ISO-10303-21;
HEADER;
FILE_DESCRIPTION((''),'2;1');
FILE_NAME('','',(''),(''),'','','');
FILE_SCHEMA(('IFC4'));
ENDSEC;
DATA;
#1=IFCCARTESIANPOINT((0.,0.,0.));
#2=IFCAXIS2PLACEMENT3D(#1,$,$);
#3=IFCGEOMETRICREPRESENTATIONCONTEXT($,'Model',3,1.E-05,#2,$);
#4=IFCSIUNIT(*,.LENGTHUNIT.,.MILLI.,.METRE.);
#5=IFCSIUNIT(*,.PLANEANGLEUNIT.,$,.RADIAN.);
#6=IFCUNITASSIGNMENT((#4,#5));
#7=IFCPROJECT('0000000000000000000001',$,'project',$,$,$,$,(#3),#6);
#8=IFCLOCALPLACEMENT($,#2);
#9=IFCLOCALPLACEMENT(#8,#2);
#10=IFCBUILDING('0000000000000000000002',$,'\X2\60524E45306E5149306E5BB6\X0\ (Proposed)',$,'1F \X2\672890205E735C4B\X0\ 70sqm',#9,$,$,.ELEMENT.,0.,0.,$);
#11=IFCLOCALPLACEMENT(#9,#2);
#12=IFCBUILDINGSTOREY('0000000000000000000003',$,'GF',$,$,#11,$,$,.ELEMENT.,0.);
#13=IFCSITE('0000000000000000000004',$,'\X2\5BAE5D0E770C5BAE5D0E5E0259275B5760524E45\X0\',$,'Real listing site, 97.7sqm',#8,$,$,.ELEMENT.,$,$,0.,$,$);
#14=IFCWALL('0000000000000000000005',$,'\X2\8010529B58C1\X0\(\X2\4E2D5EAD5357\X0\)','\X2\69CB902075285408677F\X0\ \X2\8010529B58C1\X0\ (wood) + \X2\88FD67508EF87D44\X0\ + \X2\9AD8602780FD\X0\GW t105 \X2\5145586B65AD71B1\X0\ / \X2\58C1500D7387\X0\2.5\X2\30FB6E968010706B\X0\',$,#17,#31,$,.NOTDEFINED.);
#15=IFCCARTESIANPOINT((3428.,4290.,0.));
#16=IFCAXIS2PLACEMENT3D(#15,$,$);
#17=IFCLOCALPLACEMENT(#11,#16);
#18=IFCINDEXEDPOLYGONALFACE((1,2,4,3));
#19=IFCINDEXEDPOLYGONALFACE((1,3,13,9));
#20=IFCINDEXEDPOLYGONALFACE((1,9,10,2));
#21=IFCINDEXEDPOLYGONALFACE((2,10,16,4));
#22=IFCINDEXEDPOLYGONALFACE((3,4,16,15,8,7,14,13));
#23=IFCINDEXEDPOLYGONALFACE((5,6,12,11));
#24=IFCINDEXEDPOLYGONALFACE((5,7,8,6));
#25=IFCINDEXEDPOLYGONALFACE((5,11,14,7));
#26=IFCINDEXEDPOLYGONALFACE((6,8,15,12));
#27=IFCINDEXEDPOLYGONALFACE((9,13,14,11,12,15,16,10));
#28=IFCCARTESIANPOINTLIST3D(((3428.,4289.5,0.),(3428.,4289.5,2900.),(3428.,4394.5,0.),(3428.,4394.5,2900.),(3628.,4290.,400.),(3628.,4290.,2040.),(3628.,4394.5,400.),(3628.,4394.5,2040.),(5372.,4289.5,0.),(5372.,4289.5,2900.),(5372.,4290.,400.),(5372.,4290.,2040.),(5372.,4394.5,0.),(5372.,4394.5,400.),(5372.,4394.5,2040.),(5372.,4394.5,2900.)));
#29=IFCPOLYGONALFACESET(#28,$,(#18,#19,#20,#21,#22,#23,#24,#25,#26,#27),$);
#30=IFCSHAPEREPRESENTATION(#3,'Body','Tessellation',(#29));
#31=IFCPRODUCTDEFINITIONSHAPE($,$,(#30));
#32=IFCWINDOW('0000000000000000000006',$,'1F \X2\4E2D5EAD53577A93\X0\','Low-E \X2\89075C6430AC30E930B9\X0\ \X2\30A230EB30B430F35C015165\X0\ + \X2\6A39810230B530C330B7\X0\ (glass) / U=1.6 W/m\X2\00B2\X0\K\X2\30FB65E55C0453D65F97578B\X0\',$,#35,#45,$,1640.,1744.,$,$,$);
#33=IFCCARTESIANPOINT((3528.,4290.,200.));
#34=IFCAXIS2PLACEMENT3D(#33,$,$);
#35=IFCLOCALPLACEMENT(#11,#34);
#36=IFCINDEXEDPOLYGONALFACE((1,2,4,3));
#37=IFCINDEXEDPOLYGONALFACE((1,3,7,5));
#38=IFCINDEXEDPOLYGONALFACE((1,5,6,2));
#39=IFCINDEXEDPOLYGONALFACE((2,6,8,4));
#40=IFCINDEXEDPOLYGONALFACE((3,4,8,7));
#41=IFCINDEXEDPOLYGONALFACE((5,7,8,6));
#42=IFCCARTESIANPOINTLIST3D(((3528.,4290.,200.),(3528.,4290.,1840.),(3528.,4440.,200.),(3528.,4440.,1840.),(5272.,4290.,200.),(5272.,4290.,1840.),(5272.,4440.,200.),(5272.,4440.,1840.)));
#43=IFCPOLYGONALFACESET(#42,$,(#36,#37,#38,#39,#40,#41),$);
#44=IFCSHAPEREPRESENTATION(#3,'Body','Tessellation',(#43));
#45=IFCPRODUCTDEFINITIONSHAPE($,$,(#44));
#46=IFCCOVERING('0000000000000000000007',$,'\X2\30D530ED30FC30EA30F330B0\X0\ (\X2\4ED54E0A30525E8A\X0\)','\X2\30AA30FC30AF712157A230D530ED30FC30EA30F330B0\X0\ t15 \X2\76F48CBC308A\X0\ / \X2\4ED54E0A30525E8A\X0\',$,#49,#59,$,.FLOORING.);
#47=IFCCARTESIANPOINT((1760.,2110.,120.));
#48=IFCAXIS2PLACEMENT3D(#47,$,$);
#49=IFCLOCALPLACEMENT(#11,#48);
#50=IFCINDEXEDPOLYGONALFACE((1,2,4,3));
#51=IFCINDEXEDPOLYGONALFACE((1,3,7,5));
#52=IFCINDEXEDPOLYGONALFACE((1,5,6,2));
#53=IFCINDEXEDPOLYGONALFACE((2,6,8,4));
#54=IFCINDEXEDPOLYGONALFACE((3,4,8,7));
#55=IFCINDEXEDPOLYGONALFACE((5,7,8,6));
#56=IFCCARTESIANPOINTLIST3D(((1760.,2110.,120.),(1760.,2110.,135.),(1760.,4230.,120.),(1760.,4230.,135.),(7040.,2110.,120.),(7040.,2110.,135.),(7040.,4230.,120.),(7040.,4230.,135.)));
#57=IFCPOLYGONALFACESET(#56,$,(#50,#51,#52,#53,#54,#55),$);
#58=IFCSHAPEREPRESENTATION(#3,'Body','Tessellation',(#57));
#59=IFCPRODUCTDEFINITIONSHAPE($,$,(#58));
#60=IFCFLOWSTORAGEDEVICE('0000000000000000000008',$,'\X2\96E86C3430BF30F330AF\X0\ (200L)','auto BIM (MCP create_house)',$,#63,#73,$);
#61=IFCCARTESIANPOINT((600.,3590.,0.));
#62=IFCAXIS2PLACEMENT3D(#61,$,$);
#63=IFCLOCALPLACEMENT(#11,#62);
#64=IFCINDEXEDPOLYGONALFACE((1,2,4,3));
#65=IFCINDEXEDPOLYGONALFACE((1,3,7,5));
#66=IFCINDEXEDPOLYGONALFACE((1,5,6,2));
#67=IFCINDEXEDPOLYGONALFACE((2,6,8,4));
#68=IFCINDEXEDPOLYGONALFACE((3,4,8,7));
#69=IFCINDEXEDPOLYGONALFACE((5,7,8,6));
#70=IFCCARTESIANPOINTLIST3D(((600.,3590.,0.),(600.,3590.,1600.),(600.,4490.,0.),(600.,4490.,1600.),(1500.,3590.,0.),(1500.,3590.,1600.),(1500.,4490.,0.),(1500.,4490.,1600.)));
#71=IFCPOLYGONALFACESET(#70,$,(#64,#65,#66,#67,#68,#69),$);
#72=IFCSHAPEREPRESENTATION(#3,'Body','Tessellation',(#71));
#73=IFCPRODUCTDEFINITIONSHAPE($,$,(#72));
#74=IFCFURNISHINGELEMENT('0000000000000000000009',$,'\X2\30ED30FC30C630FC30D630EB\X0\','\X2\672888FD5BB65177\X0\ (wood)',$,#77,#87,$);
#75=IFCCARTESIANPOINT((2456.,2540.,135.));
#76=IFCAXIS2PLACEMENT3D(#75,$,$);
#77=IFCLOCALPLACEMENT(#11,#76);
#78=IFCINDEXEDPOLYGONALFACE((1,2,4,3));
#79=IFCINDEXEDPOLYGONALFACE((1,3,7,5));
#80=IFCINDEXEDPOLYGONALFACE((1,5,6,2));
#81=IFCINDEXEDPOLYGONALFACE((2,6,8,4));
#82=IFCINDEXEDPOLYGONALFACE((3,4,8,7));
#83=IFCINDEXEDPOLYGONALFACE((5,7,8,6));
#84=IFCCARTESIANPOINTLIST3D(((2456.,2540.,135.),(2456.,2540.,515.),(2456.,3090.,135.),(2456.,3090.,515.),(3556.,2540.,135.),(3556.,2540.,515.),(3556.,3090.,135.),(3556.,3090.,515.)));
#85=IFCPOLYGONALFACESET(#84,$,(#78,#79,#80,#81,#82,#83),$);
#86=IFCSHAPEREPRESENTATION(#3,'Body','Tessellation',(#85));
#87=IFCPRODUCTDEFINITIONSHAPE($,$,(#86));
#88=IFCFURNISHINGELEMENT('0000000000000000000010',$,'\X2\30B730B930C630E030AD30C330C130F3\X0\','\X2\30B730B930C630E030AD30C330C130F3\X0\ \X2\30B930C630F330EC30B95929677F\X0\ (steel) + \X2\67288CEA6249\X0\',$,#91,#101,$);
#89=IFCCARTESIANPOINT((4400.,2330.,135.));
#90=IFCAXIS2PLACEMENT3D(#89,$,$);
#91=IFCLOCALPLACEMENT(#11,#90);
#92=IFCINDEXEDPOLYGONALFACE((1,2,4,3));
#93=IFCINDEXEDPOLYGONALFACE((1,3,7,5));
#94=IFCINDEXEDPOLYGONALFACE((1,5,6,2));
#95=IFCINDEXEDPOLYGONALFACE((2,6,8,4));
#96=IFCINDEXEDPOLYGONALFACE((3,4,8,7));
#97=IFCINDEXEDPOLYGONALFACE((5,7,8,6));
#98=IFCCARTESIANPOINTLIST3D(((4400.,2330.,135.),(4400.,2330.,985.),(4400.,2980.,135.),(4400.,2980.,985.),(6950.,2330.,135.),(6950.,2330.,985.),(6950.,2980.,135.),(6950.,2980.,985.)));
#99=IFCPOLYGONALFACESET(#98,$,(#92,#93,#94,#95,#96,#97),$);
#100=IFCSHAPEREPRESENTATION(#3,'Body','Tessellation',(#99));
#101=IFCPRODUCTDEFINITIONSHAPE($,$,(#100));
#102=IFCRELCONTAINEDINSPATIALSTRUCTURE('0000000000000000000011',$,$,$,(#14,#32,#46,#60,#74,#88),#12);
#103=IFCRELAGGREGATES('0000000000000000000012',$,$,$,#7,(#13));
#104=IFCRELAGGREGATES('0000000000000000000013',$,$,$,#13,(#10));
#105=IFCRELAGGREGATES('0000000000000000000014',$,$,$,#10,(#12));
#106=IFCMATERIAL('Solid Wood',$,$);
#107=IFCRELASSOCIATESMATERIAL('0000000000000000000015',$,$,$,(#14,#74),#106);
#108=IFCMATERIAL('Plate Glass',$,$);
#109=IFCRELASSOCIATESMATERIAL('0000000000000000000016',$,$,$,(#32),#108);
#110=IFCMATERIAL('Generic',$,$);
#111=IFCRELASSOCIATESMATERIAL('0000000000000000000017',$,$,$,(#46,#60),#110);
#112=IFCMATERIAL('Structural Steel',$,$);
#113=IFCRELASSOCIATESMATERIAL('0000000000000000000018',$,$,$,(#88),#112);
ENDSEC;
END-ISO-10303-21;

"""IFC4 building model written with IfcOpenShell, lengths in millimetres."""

from ifc_helpers import new_model, si_unit, frame, frame_2d, origin, place, context, project, spatial, rectangle, extrude, material, element, fill, save


model = new_model("IFC4")

# Units and contexts
model_context = context("Model", 3, precision=1e-05, world=origin())
ifc_project = project(units=[si_unit("LENGTHUNIT", "METRE", prefix="MILLI"), si_unit("PLANEANGLEUNIT", "RADIAN")], contexts=[model_context])

# Site, building, storey
site_placement = place(None, origin())
site = spatial("IfcSite", under=ifc_project, at=site_placement, Name="宮崎県宮崎市大字恒久", ObjectType="Real listing site, 97.7sqm", CompositionType="ELEMENT", RefElevation=0.0)
building_placement = place(site_placement, origin())
building = spatial("IfcBuilding", under=site, at=building_placement, Name="恒久の光の家 (Proposed)", ObjectType="1F 木造平屋 70sqm", CompositionType="ELEMENT", ElevationOfRefHeight=0.0, ElevationOfTerrain=0.0)
storey_placement = place(building_placement, origin())
storey = spatial("IfcBuildingStorey", under=building, at=storey_placement, Name="GF", CompositionType="ELEMENT", Elevation=0.0)

# Shared definitions
ifc_material_1 = material(Name="Solid Wood")

# Shared definitions
ifc_material_2 = material(Name="Plate Glass")

# Wall, opening, window
wall_1_placement = place(storey_placement, frame((3428.0, 4290.0, 0.0)))
wall_1 = element("IfcWall", 1, at=wall_1_placement, inside=storey, material=ifc_material_1, Name="耐力壁(中庭南)", Description="構造用合板 耐力壁 (wood) + 製材軸組 + 高性能GW t105 充填断熱 / 壁倍率2.5・準耐火", PredefinedType="NOTDEFINED", context=model_context, shape_type="SweptSolid", body=[
    extrude(rectangle(XDim=1944.0, YDim=105.0, at=frame_2d((972.0, 52.0))), frame((3428.0, 4290.0, 0.0)), (0.0, 0.0, 1.0), 2900.0),
])
opening_1_placement = place(storey_placement, frame((3528.0, 4290.0, 200.0)))
opening_1 = element("IfcOpeningElement", 2, at=opening_1_placement, cuts=wall_1, PredefinedType="NOTDEFINED", context=model_context, shape_type="SweptSolid", body=[
    extrude(rectangle(XDim=1744.0, YDim=150.0, at=frame_2d((872.0, 75.0))), frame((3528.0, 4290.0, 200.0)), (0.0, 0.0, 1.0), 1640.0),
])
window_1_placement = place(storey_placement, frame((3528.0, 4290.0, 200.0)))
window_1 = element("IfcWindow", 3, at=window_1_placement, inside=storey, material=ifc_material_2, Name="1F 中庭南窓", Description="Low-E 複層ガラス アルゴン封入 + 樹脂サッシ (glass) / U=1.6 W/m²K・日射取得型", OverallHeight=1640.0, OverallWidth=1744.0, context=model_context, shape_type="SweptSolid", body=[
    extrude(rectangle(XDim=1744.0, YDim=150.0, at=frame_2d((872.0, 75.0))), frame((3528.0, 4290.0, 200.0)), (0.0, 0.0, 1.0), 1640.0),
])
fill(opening_1, window_1)

# Covering
ifc_material_3 = material(Name="Generic")
covering_placement = place(storey_placement, frame((1760.0, 2110.0, 120.0)))
element("IfcCovering", 4, at=covering_placement, inside=storey, material=ifc_material_3, Name="フローリング (仕上げ床)", Description="オーク無垢フローリング t15 直貼り / 仕上げ床", PredefinedType="FLOORING", context=model_context, shape_type="SweptSolid", body=[
    extrude(rectangle(XDim=5280.0, YDim=2120.0, at=frame_2d((2640.0, 1060.0))), frame((1760.0, 2110.0, 120.0)), (0.0, 0.0, 1.0), 15.0),
])

# Flow storage device
flow_storage_device_placement = place(storey_placement, frame((600.0, 3590.0, 0.0)))
element("IfcFlowStorageDevice", 5, at=flow_storage_device_placement, inside=storey, material=ifc_material_3, Name="雨水タンク (200L)", Description="auto BIM (MCP create_house)", context=model_context, shape_type="SweptSolid", body=[
    extrude(rectangle(XDim=900.0, YDim=900.0, at=frame_2d((450.0, 450.0))), frame((600.0, 3590.0, 0.0)), (0.0, 0.0, 1.0), 1600.0),
])

# Furnishing elements
furnishing_1_placement = place(storey_placement, frame((2456.0, 2540.0, 135.0)))
element("IfcFurnishingElement", 6, at=furnishing_1_placement, inside=storey, material=ifc_material_1, Name="ローテーブル", Description="木製家具 (wood)", context=model_context, shape_type="SweptSolid", body=[
    extrude(rectangle(XDim=1100.0, YDim=550.0, at=frame_2d((550.0, 275.0))), frame((2456.0, 2540.0, 135.0)), (0.0, 0.0, 1.0), 380.0),
])
ifc_material_4 = material(Name="Structural Steel")
furnishing_2_placement = place(storey_placement, frame((4400.0, 2330.0, 135.0)))
element("IfcFurnishingElement", 7, at=furnishing_2_placement, inside=storey, material=ifc_material_4, Name="システムキッチン", Description="システムキッチン ステンレス天板 (steel) + 木質扉", context=model_context, shape_type="SweptSolid", body=[
    extrude(rectangle(XDim=2550.0, YDim=650.0, at=frame_2d((1275.0, 325.0))), frame((4400.0, 2330.0, 135.0)), (0.0, 0.0, 1.0), 850.0),
])

save(model, "model.ifc")
